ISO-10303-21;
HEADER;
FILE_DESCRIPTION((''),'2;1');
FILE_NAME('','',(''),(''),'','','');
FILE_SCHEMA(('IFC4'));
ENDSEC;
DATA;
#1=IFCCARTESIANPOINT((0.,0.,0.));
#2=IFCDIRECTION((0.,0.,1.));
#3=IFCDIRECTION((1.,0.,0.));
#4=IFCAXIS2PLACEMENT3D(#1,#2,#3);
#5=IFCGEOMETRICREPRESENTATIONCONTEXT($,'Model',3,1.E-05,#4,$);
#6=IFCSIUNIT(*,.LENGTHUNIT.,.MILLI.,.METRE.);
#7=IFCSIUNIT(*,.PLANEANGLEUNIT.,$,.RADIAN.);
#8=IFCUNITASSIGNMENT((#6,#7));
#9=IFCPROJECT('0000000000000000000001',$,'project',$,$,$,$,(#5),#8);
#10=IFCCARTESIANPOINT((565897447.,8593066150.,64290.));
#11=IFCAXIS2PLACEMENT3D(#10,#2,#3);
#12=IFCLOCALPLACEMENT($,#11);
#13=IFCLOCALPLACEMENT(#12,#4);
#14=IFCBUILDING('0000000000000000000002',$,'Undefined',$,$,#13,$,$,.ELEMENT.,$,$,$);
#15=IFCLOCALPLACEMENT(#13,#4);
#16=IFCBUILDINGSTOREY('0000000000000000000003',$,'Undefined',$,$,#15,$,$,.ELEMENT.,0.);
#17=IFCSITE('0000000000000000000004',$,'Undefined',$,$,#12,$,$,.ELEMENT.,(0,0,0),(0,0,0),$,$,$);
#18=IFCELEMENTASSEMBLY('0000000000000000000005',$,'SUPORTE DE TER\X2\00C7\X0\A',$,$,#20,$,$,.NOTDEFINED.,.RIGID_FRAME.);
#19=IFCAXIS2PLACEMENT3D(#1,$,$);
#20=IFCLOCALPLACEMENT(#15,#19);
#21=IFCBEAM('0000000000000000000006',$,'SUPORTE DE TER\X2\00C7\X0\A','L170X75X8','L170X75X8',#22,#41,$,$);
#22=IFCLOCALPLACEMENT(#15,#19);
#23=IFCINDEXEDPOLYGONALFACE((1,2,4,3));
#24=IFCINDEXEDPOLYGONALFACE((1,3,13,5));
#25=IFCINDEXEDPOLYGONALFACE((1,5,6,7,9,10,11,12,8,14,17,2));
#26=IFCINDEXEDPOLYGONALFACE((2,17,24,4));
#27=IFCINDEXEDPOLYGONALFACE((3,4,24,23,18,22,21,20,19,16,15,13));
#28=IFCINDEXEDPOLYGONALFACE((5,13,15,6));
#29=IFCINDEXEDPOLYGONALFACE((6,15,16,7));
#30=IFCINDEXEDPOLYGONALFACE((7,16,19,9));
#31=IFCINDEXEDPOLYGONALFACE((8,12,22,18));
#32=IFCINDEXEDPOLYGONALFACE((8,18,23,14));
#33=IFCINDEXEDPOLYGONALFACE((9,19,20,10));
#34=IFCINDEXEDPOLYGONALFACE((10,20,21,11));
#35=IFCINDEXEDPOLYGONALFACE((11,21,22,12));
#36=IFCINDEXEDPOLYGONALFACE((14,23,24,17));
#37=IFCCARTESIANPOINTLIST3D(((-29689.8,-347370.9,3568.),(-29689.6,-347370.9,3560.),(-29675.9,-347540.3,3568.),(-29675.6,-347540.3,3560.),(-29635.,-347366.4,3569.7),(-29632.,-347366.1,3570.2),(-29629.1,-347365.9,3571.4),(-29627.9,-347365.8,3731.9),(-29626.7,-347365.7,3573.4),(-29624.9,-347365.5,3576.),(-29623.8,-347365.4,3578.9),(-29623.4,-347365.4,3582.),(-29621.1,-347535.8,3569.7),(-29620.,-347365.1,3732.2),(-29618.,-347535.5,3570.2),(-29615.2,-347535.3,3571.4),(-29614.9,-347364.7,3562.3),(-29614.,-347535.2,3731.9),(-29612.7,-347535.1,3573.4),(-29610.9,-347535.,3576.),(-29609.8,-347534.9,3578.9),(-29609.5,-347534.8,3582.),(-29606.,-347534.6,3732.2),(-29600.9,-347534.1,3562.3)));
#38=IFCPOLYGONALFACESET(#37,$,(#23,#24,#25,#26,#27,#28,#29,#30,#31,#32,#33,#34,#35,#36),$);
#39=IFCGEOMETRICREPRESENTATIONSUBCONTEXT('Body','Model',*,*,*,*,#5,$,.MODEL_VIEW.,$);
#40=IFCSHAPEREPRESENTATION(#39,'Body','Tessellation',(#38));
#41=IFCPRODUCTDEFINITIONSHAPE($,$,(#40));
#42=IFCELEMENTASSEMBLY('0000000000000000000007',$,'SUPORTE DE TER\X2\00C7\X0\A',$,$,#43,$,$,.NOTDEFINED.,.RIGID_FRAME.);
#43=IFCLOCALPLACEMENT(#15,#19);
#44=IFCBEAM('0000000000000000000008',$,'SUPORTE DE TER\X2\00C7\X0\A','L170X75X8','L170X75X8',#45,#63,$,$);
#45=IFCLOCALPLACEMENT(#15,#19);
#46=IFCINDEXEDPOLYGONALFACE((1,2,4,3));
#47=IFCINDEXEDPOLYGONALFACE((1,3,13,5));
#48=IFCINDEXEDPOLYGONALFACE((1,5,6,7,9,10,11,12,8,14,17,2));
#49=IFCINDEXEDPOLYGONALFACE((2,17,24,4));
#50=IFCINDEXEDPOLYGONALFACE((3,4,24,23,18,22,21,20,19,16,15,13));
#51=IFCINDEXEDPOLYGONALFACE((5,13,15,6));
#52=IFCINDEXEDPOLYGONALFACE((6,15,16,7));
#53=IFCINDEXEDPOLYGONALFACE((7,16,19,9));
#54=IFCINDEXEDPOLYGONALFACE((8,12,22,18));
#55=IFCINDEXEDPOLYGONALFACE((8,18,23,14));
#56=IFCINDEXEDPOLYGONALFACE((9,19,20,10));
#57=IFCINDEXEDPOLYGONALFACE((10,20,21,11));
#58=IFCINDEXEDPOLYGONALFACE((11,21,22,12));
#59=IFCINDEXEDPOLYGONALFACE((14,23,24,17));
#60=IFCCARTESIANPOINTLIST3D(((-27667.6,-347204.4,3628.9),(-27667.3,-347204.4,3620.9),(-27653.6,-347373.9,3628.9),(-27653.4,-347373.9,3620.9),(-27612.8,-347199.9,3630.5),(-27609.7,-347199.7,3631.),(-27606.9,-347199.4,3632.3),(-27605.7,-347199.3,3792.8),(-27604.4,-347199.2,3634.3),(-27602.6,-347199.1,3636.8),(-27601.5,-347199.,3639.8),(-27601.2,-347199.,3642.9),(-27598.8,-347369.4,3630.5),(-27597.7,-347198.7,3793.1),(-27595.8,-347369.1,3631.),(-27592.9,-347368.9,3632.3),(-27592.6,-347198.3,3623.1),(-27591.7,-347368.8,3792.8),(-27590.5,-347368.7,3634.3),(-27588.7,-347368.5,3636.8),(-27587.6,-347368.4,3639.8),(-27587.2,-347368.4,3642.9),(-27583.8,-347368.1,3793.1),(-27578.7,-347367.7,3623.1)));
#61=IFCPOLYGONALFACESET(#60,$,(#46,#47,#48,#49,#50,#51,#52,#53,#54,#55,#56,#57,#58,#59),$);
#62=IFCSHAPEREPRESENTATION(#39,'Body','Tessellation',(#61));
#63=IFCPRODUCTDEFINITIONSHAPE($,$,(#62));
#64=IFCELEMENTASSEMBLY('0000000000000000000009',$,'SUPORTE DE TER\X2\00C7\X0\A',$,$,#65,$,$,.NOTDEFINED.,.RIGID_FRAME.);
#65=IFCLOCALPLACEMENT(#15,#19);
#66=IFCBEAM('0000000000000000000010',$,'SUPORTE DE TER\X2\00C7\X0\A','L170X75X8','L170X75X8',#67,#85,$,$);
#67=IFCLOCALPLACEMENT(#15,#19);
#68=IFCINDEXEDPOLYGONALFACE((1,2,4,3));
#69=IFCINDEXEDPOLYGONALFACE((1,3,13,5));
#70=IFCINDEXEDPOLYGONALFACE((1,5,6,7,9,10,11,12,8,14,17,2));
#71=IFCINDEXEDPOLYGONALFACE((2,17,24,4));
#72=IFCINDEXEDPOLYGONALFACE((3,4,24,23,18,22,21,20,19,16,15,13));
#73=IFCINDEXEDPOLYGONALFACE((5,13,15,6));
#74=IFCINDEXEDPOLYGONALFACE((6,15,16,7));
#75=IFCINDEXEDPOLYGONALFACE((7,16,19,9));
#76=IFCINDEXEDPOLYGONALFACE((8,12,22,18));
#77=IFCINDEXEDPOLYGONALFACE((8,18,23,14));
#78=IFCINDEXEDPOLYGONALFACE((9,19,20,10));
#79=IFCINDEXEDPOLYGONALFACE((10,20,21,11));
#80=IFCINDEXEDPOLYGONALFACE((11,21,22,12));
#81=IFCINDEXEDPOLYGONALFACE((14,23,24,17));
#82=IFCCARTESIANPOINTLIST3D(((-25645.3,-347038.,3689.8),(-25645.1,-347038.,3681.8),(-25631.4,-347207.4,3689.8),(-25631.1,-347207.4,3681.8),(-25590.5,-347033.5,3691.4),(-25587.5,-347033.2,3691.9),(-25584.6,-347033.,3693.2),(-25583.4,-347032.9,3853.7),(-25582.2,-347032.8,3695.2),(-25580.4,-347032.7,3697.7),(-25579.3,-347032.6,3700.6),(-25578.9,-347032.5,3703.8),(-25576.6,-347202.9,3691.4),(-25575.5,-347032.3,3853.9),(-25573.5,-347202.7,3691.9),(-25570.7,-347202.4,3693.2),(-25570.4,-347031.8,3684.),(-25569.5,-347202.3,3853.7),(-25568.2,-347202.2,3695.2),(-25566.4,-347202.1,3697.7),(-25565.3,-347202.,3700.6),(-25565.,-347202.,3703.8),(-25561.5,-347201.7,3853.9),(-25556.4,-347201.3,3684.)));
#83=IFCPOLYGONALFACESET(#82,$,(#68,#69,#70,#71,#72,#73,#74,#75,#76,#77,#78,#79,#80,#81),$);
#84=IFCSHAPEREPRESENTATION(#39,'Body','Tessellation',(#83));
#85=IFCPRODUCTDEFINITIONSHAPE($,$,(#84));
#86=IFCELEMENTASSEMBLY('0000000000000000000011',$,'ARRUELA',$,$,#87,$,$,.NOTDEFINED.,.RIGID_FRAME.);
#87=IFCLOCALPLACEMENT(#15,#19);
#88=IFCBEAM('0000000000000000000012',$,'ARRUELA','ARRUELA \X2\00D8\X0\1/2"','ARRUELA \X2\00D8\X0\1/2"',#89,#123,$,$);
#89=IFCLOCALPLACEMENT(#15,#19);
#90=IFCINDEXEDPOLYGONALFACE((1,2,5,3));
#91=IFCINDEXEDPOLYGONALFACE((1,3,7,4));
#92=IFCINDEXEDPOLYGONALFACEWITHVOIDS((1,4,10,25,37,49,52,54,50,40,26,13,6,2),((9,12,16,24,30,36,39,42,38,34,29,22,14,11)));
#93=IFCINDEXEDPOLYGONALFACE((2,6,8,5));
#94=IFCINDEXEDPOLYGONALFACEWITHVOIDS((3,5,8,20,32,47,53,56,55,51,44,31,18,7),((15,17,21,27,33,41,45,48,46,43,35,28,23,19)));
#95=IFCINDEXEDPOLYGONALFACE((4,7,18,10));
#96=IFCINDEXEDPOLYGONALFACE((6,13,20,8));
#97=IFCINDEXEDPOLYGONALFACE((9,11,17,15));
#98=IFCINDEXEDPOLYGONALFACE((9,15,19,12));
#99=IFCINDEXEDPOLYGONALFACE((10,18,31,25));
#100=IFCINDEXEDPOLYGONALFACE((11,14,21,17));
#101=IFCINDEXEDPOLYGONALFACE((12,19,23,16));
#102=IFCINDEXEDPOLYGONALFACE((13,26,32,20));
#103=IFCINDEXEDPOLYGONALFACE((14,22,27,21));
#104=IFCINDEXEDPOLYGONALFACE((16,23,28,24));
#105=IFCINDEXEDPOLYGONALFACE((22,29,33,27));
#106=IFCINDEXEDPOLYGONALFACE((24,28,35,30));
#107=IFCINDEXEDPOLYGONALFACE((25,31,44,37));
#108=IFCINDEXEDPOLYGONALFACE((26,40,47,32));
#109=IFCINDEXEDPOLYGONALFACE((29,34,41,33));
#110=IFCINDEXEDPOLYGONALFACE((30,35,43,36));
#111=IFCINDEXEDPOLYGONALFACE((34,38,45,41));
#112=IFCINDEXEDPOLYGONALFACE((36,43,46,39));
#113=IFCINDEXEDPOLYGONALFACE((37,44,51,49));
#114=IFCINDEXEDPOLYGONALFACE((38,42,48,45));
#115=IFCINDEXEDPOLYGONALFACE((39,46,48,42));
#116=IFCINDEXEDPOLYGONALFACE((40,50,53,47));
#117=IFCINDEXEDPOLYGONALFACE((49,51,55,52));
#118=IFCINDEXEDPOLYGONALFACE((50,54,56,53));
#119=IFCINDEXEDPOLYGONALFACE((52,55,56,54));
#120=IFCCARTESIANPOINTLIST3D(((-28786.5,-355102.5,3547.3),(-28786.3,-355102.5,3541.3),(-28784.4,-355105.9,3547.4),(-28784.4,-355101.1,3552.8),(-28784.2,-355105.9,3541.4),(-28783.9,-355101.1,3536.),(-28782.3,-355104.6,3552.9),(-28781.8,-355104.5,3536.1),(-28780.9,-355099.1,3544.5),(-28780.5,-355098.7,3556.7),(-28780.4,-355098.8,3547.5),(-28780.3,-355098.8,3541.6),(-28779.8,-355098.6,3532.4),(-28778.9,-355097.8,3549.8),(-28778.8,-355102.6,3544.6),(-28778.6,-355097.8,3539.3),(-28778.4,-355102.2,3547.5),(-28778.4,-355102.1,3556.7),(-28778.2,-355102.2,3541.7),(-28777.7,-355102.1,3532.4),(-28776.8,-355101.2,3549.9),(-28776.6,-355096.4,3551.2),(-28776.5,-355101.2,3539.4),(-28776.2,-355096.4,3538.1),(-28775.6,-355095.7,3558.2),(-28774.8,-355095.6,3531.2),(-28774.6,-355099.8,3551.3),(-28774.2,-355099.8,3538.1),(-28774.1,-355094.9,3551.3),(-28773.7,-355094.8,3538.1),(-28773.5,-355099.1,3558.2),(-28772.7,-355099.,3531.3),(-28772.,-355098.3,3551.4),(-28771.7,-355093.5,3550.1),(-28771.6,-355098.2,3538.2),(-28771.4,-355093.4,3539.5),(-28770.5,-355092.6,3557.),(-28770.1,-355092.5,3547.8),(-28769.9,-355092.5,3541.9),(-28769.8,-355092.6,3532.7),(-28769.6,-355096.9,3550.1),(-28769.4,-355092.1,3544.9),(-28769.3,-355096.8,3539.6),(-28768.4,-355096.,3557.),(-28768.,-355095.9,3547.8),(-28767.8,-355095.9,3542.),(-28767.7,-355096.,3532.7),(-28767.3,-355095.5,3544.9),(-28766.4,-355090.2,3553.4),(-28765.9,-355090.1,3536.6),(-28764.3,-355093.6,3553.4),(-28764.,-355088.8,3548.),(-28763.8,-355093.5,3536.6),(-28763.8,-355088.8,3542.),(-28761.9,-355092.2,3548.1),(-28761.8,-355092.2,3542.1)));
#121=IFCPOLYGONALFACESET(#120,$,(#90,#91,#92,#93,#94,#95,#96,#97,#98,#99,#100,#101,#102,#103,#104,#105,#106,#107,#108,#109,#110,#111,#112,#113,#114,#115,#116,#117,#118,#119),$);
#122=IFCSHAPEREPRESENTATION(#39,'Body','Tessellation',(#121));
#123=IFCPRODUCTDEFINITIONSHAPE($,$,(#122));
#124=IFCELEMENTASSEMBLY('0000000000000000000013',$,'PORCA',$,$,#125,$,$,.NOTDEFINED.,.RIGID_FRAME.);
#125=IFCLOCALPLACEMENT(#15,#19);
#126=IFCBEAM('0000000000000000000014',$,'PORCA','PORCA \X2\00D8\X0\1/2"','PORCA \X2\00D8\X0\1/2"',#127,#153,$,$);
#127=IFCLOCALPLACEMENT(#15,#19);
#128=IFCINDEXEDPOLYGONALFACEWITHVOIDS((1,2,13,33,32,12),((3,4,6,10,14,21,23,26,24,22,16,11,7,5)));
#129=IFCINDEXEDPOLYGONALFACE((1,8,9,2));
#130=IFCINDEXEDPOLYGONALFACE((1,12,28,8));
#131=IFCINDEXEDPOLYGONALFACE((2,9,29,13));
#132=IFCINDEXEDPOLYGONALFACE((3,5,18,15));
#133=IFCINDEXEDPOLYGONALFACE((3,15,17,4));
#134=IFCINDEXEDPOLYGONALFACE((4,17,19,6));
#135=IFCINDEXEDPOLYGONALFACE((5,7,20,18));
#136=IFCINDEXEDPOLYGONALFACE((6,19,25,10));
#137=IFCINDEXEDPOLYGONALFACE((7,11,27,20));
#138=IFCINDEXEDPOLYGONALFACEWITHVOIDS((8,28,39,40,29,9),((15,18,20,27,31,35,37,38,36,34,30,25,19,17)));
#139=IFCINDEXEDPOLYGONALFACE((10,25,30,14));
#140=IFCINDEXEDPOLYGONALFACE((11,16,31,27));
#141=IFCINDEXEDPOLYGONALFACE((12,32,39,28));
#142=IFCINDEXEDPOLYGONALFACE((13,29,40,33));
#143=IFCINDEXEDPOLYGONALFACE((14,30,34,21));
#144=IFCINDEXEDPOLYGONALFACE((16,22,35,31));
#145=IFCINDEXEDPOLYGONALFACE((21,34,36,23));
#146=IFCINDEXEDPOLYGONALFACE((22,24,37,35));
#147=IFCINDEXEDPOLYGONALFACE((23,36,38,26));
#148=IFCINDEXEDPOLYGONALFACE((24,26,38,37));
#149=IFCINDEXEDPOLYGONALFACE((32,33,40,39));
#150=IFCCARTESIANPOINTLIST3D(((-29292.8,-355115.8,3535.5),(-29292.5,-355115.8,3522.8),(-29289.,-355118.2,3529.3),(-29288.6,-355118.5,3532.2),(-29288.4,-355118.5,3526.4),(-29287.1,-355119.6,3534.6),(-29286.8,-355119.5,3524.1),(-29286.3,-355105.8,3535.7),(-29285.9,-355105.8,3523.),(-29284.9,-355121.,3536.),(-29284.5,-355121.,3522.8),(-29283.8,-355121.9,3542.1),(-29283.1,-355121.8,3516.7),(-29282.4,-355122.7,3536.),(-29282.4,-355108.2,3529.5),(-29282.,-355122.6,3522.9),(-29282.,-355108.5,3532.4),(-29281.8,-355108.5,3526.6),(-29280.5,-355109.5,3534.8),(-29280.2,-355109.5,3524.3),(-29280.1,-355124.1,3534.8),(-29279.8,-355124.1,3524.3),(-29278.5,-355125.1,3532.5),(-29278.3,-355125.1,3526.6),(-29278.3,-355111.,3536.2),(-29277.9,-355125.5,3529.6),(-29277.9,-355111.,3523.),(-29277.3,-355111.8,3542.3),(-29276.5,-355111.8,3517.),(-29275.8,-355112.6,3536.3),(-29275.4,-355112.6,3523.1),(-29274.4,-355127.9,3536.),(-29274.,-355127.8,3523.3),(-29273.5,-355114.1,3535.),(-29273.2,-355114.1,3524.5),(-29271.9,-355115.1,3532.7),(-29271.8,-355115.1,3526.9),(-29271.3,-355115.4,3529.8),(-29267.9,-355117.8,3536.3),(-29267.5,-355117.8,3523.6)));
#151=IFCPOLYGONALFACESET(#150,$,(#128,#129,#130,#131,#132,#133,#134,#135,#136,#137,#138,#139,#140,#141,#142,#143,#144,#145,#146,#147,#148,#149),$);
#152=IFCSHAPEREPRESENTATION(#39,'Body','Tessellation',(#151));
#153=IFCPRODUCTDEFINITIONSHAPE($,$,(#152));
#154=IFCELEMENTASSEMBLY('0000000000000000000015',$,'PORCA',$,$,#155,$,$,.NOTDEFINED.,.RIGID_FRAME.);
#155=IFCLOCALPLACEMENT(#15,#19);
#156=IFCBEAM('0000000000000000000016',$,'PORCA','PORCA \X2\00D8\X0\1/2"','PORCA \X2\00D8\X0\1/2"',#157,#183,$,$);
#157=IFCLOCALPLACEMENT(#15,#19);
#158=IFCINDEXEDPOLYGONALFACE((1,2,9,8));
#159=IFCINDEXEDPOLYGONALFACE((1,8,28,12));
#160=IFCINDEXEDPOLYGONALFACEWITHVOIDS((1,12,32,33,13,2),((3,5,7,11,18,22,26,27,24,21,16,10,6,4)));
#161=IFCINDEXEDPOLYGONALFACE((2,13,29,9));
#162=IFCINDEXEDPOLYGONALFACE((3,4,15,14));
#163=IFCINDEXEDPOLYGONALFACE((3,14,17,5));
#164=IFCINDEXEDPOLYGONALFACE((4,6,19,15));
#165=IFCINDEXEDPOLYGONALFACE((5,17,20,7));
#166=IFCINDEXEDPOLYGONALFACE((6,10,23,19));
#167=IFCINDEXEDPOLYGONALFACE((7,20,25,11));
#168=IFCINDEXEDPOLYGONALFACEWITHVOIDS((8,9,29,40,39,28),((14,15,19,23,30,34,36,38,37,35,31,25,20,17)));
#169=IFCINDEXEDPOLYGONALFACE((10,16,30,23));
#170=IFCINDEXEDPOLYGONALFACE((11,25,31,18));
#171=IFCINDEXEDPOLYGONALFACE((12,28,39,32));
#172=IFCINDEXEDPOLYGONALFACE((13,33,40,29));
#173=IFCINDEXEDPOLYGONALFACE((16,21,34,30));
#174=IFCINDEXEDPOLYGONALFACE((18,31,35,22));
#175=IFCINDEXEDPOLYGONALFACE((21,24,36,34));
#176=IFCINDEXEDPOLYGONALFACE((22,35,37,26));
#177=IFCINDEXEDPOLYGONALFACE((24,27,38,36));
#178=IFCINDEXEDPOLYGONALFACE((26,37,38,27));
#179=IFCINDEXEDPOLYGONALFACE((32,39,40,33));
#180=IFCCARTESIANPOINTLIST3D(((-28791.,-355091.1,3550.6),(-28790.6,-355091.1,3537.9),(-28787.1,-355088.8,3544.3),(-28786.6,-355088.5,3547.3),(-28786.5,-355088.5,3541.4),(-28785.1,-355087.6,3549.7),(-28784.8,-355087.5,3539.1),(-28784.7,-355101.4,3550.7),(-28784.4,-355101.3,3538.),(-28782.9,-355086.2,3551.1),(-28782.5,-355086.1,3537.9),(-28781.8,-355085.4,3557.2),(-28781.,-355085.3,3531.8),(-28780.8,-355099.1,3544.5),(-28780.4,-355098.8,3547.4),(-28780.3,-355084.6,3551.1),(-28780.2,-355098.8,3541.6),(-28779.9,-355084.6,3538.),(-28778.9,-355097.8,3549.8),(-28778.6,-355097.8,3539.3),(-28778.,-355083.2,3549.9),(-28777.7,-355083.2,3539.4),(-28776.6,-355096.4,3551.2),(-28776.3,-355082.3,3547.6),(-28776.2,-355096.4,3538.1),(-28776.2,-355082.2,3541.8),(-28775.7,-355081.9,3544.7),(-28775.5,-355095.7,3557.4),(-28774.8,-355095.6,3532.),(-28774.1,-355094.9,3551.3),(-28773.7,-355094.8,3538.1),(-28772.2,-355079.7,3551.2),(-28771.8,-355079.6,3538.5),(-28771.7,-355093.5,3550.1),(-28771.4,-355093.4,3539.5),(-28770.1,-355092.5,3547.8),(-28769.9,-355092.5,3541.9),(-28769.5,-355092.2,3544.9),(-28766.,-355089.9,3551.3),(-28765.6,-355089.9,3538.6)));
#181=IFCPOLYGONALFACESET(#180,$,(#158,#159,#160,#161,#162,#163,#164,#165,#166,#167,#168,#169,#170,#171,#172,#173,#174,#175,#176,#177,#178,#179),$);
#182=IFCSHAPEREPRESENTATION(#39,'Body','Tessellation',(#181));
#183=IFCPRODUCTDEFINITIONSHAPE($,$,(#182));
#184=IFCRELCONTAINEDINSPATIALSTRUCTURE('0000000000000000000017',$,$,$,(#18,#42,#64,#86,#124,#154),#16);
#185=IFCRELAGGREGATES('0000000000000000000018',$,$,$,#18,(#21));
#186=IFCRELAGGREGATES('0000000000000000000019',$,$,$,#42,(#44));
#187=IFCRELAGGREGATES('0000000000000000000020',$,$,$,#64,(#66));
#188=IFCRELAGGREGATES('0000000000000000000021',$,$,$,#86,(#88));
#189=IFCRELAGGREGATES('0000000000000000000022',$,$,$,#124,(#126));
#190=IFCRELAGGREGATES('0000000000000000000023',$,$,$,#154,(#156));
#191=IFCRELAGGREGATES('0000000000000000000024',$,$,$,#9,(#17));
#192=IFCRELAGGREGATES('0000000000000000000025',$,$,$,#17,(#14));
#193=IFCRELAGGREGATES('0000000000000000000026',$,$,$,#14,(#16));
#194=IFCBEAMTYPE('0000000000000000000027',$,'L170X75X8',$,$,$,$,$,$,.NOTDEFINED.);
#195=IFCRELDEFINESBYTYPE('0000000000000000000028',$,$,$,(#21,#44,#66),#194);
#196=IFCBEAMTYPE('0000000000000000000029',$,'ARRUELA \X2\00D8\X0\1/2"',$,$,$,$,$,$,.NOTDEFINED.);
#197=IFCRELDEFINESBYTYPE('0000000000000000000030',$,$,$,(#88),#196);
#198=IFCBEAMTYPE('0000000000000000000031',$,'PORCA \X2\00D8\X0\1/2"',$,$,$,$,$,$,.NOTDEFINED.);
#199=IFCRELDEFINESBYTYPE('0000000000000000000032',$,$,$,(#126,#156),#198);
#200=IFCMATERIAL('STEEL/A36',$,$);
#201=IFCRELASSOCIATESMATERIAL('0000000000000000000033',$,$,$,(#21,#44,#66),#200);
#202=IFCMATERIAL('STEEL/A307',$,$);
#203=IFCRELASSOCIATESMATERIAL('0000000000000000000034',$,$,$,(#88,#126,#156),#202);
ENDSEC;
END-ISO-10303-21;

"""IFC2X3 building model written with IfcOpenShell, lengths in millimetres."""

from ifc_helpers import new_model, si_unit, frame, origin_with_axes, origin_2d_with_axis, place, context, subcontext, project, spatial, polyline, l_section, outline, extrude, material, type_object, element, aggregate, save


model = new_model("IFC2X3")

# Units and contexts
model_context = context("Model", 3, precision=1e-05, world=origin_with_axes())
body_context = subcontext(model_context, "Body", "Model", "MODEL_VIEW")
ifc_project = project(units=[si_unit("LENGTHUNIT", "METRE", prefix="MILLI"), si_unit("PLANEANGLEUNIT", "RADIAN")], contexts=[model_context])

# Site, building, storey
site_placement = place(None, frame((565897447.0, 8593066150.0, 64290.0), z_axis=(0.0, 0.0, 1.0), x_axis=(1.0, 0.0, 0.0)))
site = spatial("IfcSite", under=ifc_project, at=site_placement, Name="Undefined", CompositionType="ELEMENT", RefLatitude=(0, 0, 0), RefLongitude=(0, 0, 0))
building_placement = place(site_placement, origin_with_axes())
building = spatial("IfcBuilding", under=site, at=building_placement, Name="Undefined", CompositionType="ELEMENT")
storey_placement = place(building_placement, origin_with_axes())
storey = spatial("IfcBuildingStorey", under=building, at=storey_placement, Name="Undefined", CompositionType="ELEMENT", Elevation=0.0)

# Element assemblies, beams
ifc_material_1 = material(Name="STEEL/A36")
beam_type_1 = type_object("IfcBeamType", Name="L170X75X8", PredefinedType="NOTDEFINED")
assembly_1_placement = place(storey_placement, origin_with_axes())
assembly_1 = element("IfcElementAssembly", 1, at=assembly_1_placement, inside=storey, Name="SUPORTE DE TERÇA", AssemblyPlace="NOTDEFINED", PredefinedType="RIGID_FRAME")
beam_1_placement = place(assembly_1_placement, frame((-29654.8, -347368.0, 3646.1), z_axis=(-0.029885, -0.00246, 0.99955), x_axis=(0.082025, -0.99663, 0.0)))
beam_1 = element("IfcBeam", 2, at=beam_1_placement, type_object=beam_type_1, material=ifc_material_1, Name="SUPORTE DE TERÇA", Description="L170X75X8", ObjectType="L170X75X8", context=body_context, shape_type="SweptSolid", body=[
    extrude(l_section(Depth=170.0, Width=75.0, Thickness=8.0, FilletRadius=12.0, at=origin_2d_with_axis()), frame((170.0, 0.0, 0.0), z_axis=(-1.0, 0.0, 0.0), x_axis=(0.0, -1.0, 0.0)), (0.0, 0.0, 1.0), 170.0),
])
aggregate(assembly_1, [beam_1])
assembly_2_placement = place(storey_placement, origin_with_axes())
assembly_2 = element("IfcElementAssembly", 3, at=assembly_2_placement, inside=storey, Name="SUPORTE DE TERÇA", AssemblyPlace="NOTDEFINED", PredefinedType="RIGID_FRAME")
beam_2_placement = place(assembly_2_placement, frame((-27632.5, -347201.6, 3707.0), z_axis=(-0.029885, -0.00246, 0.99955), x_axis=(0.082025, -0.99663, 0.0)))
beam_2 = element("IfcBeam", 4, at=beam_2_placement, type_object=beam_type_1, material=ifc_material_1, Name="SUPORTE DE TERÇA", Description="L170X75X8", ObjectType="L170X75X8", context=body_context, shape_type="SweptSolid", body=[
    extrude(l_section(Depth=170.0, Width=75.0, Thickness=8.0, FilletRadius=12.0, at=origin_2d_with_axis()), frame((170.0, 0.0, 0.0), z_axis=(-1.0, 0.0, 0.0), x_axis=(0.0, -1.0, 0.0)), (0.0, 0.0, 1.0), 170.0),
])
aggregate(assembly_2, [beam_2])
assembly_3_placement = place(storey_placement, origin_with_axes())
assembly_3 = element("IfcElementAssembly", 5, at=assembly_3_placement, inside=storey, Name="SUPORTE DE TERÇA", AssemblyPlace="NOTDEFINED", PredefinedType="RIGID_FRAME")
beam_3_placement = place(assembly_3_placement, frame((-25610.3, -347035.1, 3767.8), z_axis=(-0.029885, -0.00246, 0.99955), x_axis=(0.082025, -0.99663, 0.0)))
beam_3 = element("IfcBeam", 6, at=beam_3_placement, type_object=beam_type_1, material=ifc_material_1, Name="SUPORTE DE TERÇA", Description="L170X75X8", ObjectType="L170X75X8", context=body_context, shape_type="SweptSolid", body=[
    extrude(l_section(Depth=170.0, Width=75.0, Thickness=8.0, FilletRadius=12.0, at=origin_2d_with_axis()), frame((170.0, 0.0, 0.0), z_axis=(-1.0, 0.0, 0.0), x_axis=(0.0, -1.0, 0.0)), (0.0, 0.0, 1.0), 170.0),
])
aggregate(assembly_3, [beam_3])
assembly_4_placement = place(storey_placement, origin_with_axes())
assembly_4 = element("IfcElementAssembly", 7, at=assembly_4_placement, inside=storey, Name="ARRUELA", AssemblyPlace="NOTDEFINED", PredefinedType="RIGID_FRAME")
ifc_material_2 = material(Name="STEEL/A307")
beam_type_2 = type_object("IfcBeamType", Name="ARRUELA Ø1/2\"", PredefinedType="NOTDEFINED")
beam_4_placement = place(assembly_4_placement, frame((-28775.2, -355095.6, 3544.7), z_axis=(0.853486, 0.520426, 0.026799), x_axis=(0.520257, -0.853904, 0.013454)))
beam_4 = element("IfcBeam", 8, at=beam_4_placement, type_object=beam_type_2, material=ifc_material_2, Name="ARRUELA", Description="ARRUELA Ø1/2\"", ObjectType="ARRUELA Ø1/2\"", context=body_context, shape_type="SweptSolid", body=[
    extrude(outline(polyline([(-8.4, 10.5), (-3.0, 13.2), (3.0, 13.2), (8.4, 10.5), (12.2, 5.9), (13.5, 0.0), (12.2, -5.9), (8.4, -10.5), (3.0, -13.2), (-3.0, -13.2), (-8.4, -10.5), (-12.2, -5.9), (-13.5, 0.0), (-12.2, 5.9), (-8.4, 10.5)]), holes=[polyline([(5.3, 4.2), (2.9, 6.1), (0.0, 6.7), (-2.9, 6.1), (-5.3, 4.2), (-6.6, 1.5), (-6.6, -1.5), (-5.3, -4.2), (-2.9, -6.1), (0.0, -6.8), (2.9, -6.1), (5.3, -4.2), (6.6, -1.5), (6.6, 1.5), (5.3, 4.2)])]), frame((4.0, 0.0, 0.0), z_axis=(-1.0, 0.0, 0.0), x_axis=(0.0, -1.0, 0.0)), (0.0, 0.0, 1.0), 4.0),
])
aggregate(assembly_4, [beam_4])
assembly_5_placement = place(storey_placement, origin_with_axes())
assembly_5 = element("IfcElementAssembly", 9, at=assembly_5_placement, inside=storey, Name="PORCA", AssemblyPlace="NOTDEFINED", PredefinedType="RIGID_FRAME")
beam_type_3 = type_object("IfcBeamType", Name="PORCA Ø1/2\"", PredefinedType="NOTDEFINED")
beam_5_placement = place(assembly_5_placement, frame((-29276.9, -355111.8, 3529.6), z_axis=(0.836984, -0.546715, 0.02368), x_axis=(-0.546411, -0.837315, -0.018398)))
beam_5 = element("IfcBeam", 10, at=beam_5_placement, type_object=beam_type_3, material=ifc_material_2, Name="PORCA", Description="PORCA Ø1/2\"", ObjectType="PORCA Ø1/2\"", context=body_context, shape_type="SweptSolid", body=[
    extrude(outline(polyline([(-12.7, 0.0), (-6.3, 11.0), (6.3, 11.0), (12.7, 0.0), (6.3, -11.0), (-6.3, -11.0), (-12.7, 0.0)]), holes=[polyline([(5.3, 4.2), (2.9, 6.0), (0.0, 6.7), (-2.9, 6.0), (-5.3, 4.2), (-6.6, 1.5), (-6.6, -1.5), (-5.3, -4.2), (-2.9, -6.0), (0.0, -6.7), (2.9, -6.0), (5.3, -4.2), (6.6, -1.5), (6.6, 1.5), (5.3, 4.2)])]), frame((12.0, 0.0, 0.0), z_axis=(-1.0, 0.0, 0.0), x_axis=(0.0, -1.0, 0.0)), (0.0, 0.0, 1.0), 12.0),
])
aggregate(assembly_5, [beam_5])
assembly_6_placement = place(storey_placement, origin_with_axes())
assembly_6 = element("IfcElementAssembly", 11, at=assembly_6_placement, inside=storey, Name="PORCA", AssemblyPlace="NOTDEFINED", PredefinedType="RIGID_FRAME")
beam_6_placement = place(assembly_6_placement, frame((-28781.4, -355085.4, 3544.5), z_axis=(0.853486, 0.520426, 0.026799), x_axis=(0.520257, -0.853904, 0.013454)))
beam_6 = element("IfcBeam", 12, at=beam_6_placement, type_object=beam_type_3, material=ifc_material_2, Name="PORCA", Description="PORCA Ø1/2\"", ObjectType="PORCA Ø1/2\"", context=body_context, shape_type="SweptSolid", body=[
    extrude(outline(polyline([(-12.7, 0.0), (-6.3, 11.0), (6.3, 11.0), (12.7, 0.0), (6.3, -11.0), (-6.3, -11.0), (-12.7, 0.0)]), holes=[polyline([(5.3, 4.2), (2.9, 6.0), (0.0, 6.7), (-2.9, 6.0), (-5.3, 4.2), (-6.6, 1.5), (-6.6, -1.5), (-5.3, -4.2), (-2.9, -6.0), (0.0, -6.7), (2.9, -6.0), (5.3, -4.2), (6.6, -1.5), (6.6, 1.5), (5.3, 4.2)])]), frame((12.0, 0.0, 0.0), z_axis=(-1.0, 0.0, 0.0), x_axis=(0.0, -1.0, 0.0)), (0.0, 0.0, 1.0), 12.0),
])
aggregate(assembly_6, [beam_6])

save(model, "model.ifc")
